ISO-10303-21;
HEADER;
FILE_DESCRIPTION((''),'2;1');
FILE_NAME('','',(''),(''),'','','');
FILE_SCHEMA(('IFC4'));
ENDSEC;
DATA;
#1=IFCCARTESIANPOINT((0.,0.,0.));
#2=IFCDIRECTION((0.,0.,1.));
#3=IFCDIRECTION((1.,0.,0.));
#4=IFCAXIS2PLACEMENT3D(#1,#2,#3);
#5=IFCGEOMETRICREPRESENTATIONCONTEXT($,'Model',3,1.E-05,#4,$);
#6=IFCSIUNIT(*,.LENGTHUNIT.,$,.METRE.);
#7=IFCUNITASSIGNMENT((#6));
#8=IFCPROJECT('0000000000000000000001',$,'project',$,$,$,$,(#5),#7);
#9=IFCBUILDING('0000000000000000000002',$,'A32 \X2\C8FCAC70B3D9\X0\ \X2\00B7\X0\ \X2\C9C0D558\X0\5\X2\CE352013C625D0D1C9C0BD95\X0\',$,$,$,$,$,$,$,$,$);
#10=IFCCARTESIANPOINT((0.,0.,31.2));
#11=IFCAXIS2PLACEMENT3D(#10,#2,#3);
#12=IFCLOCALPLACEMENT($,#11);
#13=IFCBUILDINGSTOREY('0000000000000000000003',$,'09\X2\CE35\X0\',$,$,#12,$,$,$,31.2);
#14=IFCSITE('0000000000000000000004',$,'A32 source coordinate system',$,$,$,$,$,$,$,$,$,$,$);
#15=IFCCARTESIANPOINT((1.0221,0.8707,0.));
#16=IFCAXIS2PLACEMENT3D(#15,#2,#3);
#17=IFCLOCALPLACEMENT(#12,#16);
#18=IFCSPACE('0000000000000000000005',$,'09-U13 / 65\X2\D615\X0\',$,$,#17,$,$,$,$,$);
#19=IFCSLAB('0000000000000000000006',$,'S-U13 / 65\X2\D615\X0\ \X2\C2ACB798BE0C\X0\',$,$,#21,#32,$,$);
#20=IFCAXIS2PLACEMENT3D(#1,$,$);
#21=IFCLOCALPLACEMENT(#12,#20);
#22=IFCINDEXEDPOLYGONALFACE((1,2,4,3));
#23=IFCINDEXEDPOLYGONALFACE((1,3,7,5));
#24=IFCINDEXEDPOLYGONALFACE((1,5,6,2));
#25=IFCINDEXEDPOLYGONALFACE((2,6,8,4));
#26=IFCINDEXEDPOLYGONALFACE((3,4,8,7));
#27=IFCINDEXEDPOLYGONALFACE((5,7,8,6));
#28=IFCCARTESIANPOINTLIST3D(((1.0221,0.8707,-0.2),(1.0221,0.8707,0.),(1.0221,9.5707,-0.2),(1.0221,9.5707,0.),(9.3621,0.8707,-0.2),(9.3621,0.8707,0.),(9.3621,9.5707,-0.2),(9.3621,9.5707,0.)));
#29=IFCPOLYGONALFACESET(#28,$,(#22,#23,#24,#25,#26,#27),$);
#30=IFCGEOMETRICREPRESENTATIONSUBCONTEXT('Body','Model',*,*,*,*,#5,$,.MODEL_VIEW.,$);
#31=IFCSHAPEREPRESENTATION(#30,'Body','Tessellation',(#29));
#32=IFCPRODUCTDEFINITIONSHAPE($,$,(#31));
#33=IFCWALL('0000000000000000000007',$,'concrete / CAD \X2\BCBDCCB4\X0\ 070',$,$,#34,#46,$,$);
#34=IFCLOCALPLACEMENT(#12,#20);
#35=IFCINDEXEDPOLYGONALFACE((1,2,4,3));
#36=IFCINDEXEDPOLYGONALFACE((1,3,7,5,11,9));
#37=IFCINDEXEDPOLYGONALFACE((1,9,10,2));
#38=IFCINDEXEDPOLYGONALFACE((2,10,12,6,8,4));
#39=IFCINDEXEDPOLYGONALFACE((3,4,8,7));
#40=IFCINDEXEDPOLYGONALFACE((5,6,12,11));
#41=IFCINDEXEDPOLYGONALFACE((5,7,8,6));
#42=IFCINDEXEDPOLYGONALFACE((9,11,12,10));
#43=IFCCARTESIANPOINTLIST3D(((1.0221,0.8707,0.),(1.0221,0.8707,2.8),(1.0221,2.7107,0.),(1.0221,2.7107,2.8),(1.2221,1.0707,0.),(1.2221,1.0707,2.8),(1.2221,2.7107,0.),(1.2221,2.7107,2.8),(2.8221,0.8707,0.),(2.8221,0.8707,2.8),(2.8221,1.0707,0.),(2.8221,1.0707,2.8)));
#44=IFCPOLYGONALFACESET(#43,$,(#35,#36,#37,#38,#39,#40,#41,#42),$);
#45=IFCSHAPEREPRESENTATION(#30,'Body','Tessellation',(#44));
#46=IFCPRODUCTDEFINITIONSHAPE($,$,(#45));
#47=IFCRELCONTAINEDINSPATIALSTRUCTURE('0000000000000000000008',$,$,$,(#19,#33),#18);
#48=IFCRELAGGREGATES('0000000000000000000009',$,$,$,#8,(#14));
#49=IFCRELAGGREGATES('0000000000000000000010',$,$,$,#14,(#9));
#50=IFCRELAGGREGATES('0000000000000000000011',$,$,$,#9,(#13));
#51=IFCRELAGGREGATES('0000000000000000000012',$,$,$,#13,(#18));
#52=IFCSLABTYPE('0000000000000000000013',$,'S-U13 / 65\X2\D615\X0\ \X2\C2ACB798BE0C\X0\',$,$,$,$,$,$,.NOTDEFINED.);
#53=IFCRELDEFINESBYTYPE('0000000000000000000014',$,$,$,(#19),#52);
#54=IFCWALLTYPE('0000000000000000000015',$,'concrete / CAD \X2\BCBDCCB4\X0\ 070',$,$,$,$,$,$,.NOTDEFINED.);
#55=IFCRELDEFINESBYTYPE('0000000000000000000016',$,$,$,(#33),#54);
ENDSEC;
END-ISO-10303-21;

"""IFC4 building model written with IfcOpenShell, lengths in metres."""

from ifc_helpers import new_model, si_unit, frame, origin, origin_with_axes, place, context, subcontext, project, spatial, polyline, outline, extrude, source, transform, mapped, type_object, type_shapes, element, save


model = new_model("IFC4")

# Units and contexts
model_context = context("Model", 3, precision=1e-05, world=origin_with_axes())
body_context = subcontext(model_context, "Body", "Model", "MODEL_VIEW")
ifc_project = project(units=[si_unit("LENGTHUNIT", "METRE")], contexts=[model_context])

# Site, building, storey, space
storey_placement = place(None, frame((0.0, 0.0, 31.2), z_axis=(0.0, 0.0, 1.0), x_axis=(1.0, 0.0, 0.0)))
space_placement = place(storey_placement, frame((1.0221, 0.8707, 0.0), z_axis=(0.0, 0.0, 1.0), x_axis=(1.0, 0.0, 0.0)))
site = spatial("IfcSite", under=ifc_project, Name="A32 source coordinate system")
building = spatial("IfcBuilding", under=site, Name="A32 주거동 · 지하5층–옥탑지붕")
storey = spatial("IfcBuildingStorey", under=building, at=storey_placement, Name="09층", Elevation=31.2)
space = spatial("IfcSpace", under=storey, at=space_placement, Name="09-U13 / 65형")

# Slab
slab_type = type_object("IfcSlabType", Name="S-U13 / 65형 슬래브", PredefinedType="NOTDEFINED")
shared_shape_1 = source(origin(), body_context, "Body", "SweptSolid", [
    extrude(outline(polyline([(0.0, 0.0), (0.0, 8.7), (8.34, 8.7), (8.34, 0.0), (0.0, 0.0)])), frame((0.0, 0.0, -0.2)), (0.0, 0.0, 1.0), 0.2),
])
type_shapes(slab_type, [shared_shape_1])
slab_placement = place(space_placement, origin_with_axes())
element("IfcSlab", 1, at=slab_placement, inside=space, type_object=slab_type, Name="S-U13 / 65형 슬래브", context=body_context, shape_type="MappedRepresentation", body=[
    mapped(shared_shape_1, transform((0.0, 0.0, 0.0), scale=1.0)),
])

# Wall
wall_type_1 = type_object("IfcWallType", Name="concrete / CAD 벽체 070", PredefinedType="NOTDEFINED")
shared_shape_2 = source(origin(), body_context, "Body", "SweptSolid", [
    extrude(outline(polyline([(0.2, 1.84), (0.2, 0.2), (1.8, 0.2), (1.8, 0.0), (0.0, 0.0), (0.0, 1.84), (0.2, 1.84)])), origin(), (0.0, 0.0, 1.0), 2.8),
])
type_shapes(wall_type_1, [shared_shape_2])
wall_1_placement = place(space_placement, origin_with_axes())
element("IfcWall", 2, at=wall_1_placement, inside=space, type_object=wall_type_1, Name="concrete / CAD 벽체 070", context=body_context, shape_type="MappedRepresentation", body=[
    mapped(shared_shape_2, transform((0.0, 0.0, 0.0), scale=1.0)),
])

save(model, "model.ifc")
